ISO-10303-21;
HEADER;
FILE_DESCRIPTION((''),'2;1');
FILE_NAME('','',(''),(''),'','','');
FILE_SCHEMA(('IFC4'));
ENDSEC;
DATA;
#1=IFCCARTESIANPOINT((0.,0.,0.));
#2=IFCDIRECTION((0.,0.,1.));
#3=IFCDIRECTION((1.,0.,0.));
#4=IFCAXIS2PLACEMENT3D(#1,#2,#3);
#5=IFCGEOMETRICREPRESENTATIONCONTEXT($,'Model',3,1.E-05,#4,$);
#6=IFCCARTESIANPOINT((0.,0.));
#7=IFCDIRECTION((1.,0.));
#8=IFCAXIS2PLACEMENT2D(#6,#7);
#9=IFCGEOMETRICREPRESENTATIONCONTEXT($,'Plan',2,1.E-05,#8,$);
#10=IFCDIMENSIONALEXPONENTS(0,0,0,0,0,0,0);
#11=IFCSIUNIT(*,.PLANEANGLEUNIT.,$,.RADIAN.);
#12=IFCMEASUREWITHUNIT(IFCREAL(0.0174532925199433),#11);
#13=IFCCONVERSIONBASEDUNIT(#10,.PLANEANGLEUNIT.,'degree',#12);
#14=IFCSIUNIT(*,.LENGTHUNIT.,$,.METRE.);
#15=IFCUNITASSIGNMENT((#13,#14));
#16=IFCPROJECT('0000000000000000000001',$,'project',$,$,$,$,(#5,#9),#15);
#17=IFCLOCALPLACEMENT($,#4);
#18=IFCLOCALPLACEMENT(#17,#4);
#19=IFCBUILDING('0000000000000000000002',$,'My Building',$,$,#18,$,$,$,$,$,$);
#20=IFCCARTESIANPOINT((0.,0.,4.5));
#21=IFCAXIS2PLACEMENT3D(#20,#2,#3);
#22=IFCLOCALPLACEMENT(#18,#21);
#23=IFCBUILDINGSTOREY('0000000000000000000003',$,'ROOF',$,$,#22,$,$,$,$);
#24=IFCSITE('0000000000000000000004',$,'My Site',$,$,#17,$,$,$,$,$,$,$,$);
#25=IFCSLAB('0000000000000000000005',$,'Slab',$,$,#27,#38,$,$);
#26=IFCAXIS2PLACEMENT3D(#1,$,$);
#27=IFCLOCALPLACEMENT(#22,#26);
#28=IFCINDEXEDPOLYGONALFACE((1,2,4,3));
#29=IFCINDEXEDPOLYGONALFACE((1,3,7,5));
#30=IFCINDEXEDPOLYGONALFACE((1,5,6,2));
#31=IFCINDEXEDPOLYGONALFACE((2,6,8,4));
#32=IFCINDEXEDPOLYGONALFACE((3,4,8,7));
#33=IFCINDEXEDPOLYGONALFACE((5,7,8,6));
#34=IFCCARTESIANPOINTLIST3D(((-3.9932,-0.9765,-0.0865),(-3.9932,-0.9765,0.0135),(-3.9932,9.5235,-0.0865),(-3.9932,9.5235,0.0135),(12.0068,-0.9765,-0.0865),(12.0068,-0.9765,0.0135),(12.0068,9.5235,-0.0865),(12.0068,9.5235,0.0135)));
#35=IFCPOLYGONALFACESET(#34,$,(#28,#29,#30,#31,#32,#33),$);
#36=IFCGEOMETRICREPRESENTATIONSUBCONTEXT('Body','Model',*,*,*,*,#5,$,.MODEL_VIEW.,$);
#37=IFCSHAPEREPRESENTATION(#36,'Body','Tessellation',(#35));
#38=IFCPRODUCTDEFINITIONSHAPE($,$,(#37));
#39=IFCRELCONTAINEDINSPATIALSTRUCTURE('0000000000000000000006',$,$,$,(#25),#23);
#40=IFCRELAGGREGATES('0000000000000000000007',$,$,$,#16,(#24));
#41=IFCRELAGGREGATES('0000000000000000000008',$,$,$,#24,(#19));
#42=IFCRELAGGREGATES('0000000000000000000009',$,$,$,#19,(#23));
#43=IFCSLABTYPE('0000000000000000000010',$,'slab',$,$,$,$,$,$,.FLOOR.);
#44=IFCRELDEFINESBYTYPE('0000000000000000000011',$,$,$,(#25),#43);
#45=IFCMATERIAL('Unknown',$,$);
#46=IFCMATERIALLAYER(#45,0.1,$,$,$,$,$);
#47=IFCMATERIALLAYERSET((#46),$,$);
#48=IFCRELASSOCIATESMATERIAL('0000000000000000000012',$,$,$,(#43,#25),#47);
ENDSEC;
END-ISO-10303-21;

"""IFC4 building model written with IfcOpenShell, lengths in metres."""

from ifc_helpers import new_model, entity, si_unit, converted_unit, frame, origin_with_axes, origin_2d_with_axis, place, context, subcontext, project, spatial, indexed_curve, outline, extrude, material, layer, layer_set, layer_usage, type_object, element, save


model = new_model("IFC4")

# Units and contexts
model_context = context("Model", 3, precision=1e-05, world=origin_with_axes())
plan_context = context("Plan", 2, precision=1e-05, world=origin_2d_with_axis())
body_context = subcontext(model_context, "Body", "Model", "MODEL_VIEW")
ifc_project = project(units=[converted_unit("PLANEANGLEUNIT", "degree", entity("IfcReal", 0.0174532925199433), si_unit("PLANEANGLEUNIT", "RADIAN"), dimensions=[0, 0, 0, 0, 0, 0, 0]), si_unit("LENGTHUNIT", "METRE")], contexts=[model_context, plan_context])

# Site, building, storey
site_placement = place(None, origin_with_axes())
site = spatial("IfcSite", under=ifc_project, at=site_placement, Name="My Site")
building_placement = place(site_placement, origin_with_axes())
building = spatial("IfcBuilding", under=site, at=building_placement, Name="My Building")
storey_placement = place(building_placement, frame((0.0, 0.0, 4.5), z_axis=(0.0, 0.0, 1.0), x_axis=(1.0, 0.0, 0.0)))
storey = spatial("IfcBuildingStorey", under=building, at=storey_placement, Name="ROOF")

# Slab
ifc_material = material(Name="Unknown")
ifc_layer = layer(ifc_material, 0.1)
ifc_layer_set = layer_set([ifc_layer])
ifc_layer_usage = layer_usage(ifc_layer_set, "AXIS3", "POSITIVE", -0.1)
slab_type = type_object("IfcSlabType", Name="slab", PredefinedType="FLOOR", material=ifc_layer_set)
slab_placement = place(storey_placement, frame((-3.9932, 9.5235, 0.0135), z_axis=(0.0, 0.0, 1.0), x_axis=(1.0, 0.0, 0.0)))
element("IfcSlab", 1, at=slab_placement, inside=storey, type_object=slab_type, material=ifc_layer_usage, Name="Slab", context=body_context, shape_type="SweptSolid", body=[
    extrude(outline(indexed_curve([(0.0, 0.0), (16.0, 0.0), (16.0, -10.5), (0.0, -10.5), (0.0, 0.0)])), frame((0.0, 0.0, -0.1), z_axis=(0.0, 0.0, 1.0), x_axis=(1.0, 0.0, 0.0)), (0.0, 0.0, 1.0), 0.1),
])

save(model, "model.ifc")
